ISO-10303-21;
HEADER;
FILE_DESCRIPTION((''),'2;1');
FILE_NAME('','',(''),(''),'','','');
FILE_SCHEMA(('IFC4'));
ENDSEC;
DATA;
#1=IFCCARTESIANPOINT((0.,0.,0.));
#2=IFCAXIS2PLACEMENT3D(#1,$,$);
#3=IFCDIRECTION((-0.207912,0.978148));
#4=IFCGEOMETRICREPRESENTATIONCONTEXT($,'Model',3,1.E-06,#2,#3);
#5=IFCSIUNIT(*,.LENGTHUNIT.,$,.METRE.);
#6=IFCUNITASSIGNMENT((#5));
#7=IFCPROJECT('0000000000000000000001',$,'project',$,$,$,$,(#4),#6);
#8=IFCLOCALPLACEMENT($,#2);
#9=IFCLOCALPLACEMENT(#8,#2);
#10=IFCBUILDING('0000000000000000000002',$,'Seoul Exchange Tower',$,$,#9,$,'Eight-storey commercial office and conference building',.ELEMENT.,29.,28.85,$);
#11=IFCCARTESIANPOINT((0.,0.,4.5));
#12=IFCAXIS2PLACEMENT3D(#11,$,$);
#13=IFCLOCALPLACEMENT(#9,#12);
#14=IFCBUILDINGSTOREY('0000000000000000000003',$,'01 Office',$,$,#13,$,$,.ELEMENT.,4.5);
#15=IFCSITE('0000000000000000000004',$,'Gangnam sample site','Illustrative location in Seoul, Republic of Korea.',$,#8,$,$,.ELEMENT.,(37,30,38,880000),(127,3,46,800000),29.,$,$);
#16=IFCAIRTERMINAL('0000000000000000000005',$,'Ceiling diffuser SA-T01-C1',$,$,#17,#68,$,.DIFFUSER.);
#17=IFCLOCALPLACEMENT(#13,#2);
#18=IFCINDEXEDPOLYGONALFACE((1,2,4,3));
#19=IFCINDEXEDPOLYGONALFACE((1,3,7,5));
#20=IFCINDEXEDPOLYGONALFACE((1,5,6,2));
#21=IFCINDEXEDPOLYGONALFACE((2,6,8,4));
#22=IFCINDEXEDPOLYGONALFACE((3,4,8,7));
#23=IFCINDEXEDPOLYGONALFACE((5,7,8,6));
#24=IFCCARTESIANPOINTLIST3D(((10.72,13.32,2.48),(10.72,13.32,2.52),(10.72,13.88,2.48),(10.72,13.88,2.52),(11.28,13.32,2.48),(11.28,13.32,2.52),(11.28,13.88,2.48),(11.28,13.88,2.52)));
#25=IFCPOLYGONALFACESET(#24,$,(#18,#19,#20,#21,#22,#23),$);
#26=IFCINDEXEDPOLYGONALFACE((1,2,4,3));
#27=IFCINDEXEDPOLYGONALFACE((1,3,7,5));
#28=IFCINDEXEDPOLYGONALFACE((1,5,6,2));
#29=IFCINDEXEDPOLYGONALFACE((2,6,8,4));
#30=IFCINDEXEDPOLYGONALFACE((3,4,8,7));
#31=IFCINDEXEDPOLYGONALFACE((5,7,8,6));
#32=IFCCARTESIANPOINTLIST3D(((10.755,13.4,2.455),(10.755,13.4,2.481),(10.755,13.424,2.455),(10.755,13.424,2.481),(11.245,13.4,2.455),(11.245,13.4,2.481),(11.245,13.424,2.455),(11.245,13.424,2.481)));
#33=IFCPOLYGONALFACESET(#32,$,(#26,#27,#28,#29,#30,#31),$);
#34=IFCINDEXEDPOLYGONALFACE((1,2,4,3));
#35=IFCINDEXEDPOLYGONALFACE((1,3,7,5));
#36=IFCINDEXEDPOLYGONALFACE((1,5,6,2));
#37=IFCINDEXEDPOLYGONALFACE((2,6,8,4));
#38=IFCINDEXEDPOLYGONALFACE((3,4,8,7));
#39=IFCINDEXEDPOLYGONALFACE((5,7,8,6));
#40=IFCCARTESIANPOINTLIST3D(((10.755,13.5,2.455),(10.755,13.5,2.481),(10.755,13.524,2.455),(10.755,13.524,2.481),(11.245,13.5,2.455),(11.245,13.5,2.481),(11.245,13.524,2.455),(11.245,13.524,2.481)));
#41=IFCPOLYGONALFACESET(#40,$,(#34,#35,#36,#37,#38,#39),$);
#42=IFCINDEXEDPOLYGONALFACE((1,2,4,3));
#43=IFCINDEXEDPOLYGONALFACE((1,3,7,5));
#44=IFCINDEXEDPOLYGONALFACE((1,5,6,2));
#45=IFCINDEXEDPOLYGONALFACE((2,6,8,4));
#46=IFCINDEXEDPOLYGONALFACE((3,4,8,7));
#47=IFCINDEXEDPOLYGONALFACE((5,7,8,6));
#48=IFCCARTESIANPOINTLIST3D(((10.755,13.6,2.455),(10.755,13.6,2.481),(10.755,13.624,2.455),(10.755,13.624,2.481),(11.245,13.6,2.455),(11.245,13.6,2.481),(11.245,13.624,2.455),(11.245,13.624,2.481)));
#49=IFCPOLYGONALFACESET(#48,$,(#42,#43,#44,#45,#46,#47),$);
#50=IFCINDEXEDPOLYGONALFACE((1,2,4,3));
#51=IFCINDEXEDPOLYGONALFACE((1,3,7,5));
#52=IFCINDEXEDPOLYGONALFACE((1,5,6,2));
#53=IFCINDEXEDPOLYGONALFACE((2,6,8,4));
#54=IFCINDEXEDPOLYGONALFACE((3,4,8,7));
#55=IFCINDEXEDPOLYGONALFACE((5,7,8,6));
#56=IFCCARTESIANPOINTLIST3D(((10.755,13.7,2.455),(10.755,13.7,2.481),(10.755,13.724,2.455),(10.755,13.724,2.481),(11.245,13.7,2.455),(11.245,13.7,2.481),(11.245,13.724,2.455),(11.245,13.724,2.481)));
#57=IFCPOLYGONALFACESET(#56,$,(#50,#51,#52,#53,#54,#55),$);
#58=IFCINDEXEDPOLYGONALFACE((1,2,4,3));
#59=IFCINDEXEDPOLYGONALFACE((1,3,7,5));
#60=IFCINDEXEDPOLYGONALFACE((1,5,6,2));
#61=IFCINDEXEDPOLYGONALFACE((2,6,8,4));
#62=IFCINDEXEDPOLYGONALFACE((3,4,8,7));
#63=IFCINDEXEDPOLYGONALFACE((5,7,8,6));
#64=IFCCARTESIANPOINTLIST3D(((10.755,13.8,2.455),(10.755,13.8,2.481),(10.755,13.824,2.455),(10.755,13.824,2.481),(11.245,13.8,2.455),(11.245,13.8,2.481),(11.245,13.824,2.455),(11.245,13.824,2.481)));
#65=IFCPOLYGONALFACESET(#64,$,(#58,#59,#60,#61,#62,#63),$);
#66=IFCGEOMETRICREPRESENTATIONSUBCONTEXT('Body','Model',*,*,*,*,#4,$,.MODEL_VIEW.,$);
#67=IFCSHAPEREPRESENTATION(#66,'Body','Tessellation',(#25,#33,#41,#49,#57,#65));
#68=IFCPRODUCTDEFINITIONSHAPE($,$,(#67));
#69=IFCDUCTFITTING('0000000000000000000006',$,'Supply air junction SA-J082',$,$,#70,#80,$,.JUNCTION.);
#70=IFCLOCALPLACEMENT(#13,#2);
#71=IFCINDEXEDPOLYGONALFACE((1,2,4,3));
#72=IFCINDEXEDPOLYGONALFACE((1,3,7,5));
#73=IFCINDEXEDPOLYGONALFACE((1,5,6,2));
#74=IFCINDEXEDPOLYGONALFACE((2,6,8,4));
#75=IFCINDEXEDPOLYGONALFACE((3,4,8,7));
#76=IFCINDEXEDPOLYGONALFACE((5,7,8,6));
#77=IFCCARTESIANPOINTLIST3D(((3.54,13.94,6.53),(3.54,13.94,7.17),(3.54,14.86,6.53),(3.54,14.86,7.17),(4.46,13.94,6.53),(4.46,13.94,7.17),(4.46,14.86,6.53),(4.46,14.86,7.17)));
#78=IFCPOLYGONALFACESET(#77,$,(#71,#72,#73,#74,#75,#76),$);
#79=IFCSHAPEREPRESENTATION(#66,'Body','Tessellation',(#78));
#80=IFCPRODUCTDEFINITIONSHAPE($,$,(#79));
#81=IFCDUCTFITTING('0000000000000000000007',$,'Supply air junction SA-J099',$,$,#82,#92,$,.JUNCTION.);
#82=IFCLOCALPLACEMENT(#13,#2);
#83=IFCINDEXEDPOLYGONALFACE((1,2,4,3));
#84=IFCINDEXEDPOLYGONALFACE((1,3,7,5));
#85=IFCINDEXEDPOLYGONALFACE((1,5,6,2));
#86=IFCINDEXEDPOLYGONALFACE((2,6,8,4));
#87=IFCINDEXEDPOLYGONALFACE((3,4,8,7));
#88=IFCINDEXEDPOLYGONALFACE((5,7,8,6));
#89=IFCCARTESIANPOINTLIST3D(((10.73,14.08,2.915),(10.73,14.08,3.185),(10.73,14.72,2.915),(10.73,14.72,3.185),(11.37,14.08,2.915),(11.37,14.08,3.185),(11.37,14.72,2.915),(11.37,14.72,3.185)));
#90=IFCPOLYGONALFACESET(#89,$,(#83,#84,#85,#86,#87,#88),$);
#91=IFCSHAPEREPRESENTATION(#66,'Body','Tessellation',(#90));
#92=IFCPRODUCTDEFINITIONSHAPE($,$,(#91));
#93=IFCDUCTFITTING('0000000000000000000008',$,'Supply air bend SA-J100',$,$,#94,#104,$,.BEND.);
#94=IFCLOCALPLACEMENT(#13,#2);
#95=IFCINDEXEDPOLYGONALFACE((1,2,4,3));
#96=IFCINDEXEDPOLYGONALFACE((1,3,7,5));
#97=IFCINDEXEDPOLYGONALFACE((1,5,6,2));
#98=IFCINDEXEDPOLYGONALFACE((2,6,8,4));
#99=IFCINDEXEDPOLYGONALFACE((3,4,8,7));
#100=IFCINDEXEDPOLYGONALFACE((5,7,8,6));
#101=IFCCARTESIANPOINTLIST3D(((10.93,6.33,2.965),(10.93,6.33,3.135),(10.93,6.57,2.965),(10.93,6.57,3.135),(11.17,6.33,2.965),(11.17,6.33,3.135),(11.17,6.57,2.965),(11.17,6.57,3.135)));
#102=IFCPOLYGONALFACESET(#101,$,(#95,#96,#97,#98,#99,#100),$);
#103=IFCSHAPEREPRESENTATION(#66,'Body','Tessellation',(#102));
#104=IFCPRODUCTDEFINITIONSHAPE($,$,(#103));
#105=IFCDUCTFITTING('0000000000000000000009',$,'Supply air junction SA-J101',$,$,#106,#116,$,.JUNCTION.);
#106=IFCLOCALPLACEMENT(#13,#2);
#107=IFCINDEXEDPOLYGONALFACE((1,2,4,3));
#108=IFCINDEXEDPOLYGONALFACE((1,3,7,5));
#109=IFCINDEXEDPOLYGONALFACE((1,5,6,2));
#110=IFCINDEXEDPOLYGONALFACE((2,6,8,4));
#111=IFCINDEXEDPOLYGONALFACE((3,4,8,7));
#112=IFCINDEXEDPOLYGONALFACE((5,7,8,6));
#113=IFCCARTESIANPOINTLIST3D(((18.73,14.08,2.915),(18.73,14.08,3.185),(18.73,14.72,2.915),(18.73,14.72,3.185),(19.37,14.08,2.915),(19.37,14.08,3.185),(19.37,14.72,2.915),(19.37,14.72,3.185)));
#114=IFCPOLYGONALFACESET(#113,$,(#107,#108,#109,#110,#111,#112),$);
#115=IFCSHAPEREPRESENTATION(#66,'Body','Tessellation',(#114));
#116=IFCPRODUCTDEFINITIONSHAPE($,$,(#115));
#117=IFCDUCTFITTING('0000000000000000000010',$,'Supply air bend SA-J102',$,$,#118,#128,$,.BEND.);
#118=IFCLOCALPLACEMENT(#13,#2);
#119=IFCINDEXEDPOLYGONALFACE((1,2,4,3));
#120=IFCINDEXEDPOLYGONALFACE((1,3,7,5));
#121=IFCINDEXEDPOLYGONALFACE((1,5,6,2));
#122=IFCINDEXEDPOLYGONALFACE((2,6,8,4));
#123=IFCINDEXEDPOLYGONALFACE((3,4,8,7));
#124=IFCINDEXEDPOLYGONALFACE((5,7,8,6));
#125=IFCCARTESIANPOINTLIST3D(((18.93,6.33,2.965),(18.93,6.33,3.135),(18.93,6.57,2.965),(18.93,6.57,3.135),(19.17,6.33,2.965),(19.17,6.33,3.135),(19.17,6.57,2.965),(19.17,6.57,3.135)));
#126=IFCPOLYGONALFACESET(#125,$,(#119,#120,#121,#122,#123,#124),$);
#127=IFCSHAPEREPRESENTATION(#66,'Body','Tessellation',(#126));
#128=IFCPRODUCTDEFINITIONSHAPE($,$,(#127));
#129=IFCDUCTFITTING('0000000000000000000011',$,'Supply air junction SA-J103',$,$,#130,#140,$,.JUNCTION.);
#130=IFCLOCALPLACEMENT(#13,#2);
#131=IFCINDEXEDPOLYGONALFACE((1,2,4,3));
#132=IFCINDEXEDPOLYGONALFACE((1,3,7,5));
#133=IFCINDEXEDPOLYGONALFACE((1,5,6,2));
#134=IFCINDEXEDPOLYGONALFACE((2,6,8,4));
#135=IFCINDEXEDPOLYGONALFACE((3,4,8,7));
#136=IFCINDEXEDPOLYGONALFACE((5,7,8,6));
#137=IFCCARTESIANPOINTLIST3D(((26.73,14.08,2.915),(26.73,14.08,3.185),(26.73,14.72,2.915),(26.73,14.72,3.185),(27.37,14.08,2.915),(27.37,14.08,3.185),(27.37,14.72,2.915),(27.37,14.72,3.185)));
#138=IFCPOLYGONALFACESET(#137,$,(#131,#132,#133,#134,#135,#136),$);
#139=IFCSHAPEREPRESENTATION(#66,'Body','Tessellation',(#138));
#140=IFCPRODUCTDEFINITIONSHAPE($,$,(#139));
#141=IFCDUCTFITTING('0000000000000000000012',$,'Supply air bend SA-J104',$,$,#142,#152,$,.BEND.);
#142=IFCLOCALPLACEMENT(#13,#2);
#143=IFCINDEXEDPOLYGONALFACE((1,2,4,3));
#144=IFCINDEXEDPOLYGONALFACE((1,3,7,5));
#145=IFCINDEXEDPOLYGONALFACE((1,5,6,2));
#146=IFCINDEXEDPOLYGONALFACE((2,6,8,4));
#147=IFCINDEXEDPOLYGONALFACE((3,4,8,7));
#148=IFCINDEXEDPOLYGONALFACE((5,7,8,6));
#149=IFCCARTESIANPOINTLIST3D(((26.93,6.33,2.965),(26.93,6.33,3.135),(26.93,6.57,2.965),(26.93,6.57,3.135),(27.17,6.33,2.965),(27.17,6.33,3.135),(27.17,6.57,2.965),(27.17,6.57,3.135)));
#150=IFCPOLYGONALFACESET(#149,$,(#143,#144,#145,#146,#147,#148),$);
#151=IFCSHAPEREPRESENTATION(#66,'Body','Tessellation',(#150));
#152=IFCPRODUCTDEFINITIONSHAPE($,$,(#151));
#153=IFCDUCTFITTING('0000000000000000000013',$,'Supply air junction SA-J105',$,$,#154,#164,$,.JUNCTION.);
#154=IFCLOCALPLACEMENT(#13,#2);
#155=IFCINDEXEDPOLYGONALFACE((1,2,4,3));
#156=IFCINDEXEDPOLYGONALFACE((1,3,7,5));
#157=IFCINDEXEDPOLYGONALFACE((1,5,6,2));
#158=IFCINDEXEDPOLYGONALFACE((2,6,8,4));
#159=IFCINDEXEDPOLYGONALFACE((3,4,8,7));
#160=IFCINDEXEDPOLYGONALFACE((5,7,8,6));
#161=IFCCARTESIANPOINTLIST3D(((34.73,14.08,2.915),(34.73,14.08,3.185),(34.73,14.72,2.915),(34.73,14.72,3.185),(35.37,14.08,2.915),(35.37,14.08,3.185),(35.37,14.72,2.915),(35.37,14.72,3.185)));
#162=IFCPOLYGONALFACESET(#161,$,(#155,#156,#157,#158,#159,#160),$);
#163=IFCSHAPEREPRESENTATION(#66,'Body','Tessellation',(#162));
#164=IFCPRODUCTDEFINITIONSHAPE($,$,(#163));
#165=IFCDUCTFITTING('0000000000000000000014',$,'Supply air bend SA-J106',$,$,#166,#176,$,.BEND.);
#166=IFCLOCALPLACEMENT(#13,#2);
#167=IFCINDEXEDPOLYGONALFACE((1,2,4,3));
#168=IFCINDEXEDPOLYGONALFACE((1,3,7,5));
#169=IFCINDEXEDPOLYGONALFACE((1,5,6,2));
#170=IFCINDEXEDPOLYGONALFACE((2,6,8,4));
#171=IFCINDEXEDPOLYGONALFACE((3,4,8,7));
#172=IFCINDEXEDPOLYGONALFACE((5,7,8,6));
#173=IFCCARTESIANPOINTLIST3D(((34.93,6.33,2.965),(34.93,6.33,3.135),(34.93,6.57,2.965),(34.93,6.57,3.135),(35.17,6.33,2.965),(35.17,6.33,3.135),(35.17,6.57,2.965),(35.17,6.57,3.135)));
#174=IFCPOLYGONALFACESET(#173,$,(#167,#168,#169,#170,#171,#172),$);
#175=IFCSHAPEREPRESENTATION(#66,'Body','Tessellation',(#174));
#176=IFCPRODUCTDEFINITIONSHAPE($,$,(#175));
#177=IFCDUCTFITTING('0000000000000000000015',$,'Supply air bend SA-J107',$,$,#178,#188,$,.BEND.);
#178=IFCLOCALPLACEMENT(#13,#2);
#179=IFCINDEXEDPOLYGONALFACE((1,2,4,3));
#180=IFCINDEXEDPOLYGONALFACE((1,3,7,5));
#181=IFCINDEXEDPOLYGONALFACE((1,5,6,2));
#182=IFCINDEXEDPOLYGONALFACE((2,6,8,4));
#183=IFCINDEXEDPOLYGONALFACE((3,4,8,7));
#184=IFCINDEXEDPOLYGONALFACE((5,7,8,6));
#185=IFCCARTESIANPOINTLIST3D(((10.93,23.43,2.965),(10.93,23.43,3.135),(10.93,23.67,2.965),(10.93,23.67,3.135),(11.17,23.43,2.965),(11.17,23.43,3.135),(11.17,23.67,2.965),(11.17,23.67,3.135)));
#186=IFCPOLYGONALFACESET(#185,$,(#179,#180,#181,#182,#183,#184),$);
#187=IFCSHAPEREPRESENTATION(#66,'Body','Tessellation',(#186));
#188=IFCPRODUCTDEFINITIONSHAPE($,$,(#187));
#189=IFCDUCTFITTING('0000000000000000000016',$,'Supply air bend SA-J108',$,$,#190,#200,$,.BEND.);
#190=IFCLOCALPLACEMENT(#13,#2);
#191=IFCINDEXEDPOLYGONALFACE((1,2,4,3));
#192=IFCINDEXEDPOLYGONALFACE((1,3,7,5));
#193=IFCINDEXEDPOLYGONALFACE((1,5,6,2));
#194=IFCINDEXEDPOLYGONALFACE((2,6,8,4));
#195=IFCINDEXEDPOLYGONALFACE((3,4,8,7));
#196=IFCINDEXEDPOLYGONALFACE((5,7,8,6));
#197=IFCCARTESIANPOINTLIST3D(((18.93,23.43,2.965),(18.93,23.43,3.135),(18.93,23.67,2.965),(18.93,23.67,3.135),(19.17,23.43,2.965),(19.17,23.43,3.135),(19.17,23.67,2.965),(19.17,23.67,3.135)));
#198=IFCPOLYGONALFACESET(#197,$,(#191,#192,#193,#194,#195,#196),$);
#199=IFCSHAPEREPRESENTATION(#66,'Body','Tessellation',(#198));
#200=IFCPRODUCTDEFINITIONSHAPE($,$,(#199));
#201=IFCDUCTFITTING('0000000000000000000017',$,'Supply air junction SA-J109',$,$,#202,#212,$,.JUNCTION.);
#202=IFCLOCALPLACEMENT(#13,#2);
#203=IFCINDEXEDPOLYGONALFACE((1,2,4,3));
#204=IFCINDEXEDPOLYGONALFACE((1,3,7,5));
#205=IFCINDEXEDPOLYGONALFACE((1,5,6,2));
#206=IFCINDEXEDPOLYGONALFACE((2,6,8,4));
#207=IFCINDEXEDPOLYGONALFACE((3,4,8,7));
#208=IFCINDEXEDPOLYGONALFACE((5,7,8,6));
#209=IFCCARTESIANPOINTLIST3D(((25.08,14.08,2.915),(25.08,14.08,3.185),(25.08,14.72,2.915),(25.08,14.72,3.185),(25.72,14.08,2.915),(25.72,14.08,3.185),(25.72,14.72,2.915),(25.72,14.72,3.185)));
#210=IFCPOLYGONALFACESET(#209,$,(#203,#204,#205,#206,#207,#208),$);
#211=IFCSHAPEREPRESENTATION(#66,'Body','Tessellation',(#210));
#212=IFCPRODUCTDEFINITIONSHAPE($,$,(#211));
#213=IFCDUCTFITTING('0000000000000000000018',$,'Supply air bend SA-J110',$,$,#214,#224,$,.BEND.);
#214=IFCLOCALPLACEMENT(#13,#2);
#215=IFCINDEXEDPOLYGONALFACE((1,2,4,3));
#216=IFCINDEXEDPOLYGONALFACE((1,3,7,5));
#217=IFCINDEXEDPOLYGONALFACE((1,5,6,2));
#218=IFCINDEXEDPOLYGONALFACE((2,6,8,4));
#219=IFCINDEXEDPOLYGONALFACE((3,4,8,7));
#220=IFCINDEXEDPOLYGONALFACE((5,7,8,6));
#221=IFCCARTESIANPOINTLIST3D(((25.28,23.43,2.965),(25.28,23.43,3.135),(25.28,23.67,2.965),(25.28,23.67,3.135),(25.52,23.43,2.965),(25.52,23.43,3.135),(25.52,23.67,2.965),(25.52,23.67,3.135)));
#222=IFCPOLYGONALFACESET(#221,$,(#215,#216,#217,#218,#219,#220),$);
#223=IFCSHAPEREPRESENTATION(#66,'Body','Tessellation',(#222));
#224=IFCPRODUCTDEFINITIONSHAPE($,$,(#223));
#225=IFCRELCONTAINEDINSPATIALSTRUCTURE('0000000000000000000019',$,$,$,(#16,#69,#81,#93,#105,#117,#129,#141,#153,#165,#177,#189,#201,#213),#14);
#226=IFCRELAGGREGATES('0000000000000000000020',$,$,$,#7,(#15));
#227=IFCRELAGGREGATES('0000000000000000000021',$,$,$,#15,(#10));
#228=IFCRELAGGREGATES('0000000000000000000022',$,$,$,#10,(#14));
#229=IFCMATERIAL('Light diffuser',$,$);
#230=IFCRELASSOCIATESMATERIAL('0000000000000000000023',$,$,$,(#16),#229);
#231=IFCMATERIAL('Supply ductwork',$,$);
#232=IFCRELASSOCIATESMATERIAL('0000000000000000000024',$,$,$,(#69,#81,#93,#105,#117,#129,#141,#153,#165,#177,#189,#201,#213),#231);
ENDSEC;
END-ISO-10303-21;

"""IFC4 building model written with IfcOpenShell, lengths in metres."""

from ifc_helpers import new_model, si_unit, direction, frame, frame_2d, origin, place, context, subcontext, project, spatial, rectangle, extrude, material, element, save


model = new_model("IFC4")

# Units and contexts
model_context = context("Model", 3, precision=1e-06, world=origin(), true_north=direction((-0.207912, 0.978148)))
body_context = subcontext(model_context, "Body", "Model", "MODEL_VIEW")
ifc_project = project(units=[si_unit("LENGTHUNIT", "METRE")], contexts=[model_context])

# Site, building, storey
site_placement = place(None, origin())
site = spatial("IfcSite", under=ifc_project, at=site_placement, Name="Gangnam sample site", Description="Illustrative location in Seoul, Republic of Korea.", CompositionType="ELEMENT", RefLatitude=(37, 30, 38, 880000), RefLongitude=(127, 3, 46, 800000), RefElevation=29.0)
building_placement = place(site_placement, origin())
building = spatial("IfcBuilding", under=site, at=building_placement, Name="Seoul Exchange Tower", LongName="Eight-storey commercial office and conference building", CompositionType="ELEMENT", ElevationOfRefHeight=29.0, ElevationOfTerrain=28.85)
storey_placement = place(building_placement, frame((0.0, 0.0, 4.5)))
storey = spatial("IfcBuildingStorey", under=building, at=storey_placement, Name="01 Office", CompositionType="ELEMENT", Elevation=4.5)

# Shared definitions
placement = place(storey_placement, origin())

# Shared definitions
ifc_material_1 = material(Name="Light diffuser")

# Air terminal
element("IfcAirTerminal", 1, at=placement, inside=storey, material=ifc_material_1, Name="Ceiling diffuser SA-T01-C1", PredefinedType="DIFFUSER", context=body_context, shape_type="SweptSolid", body=[
    extrude(rectangle(XDim=0.56, YDim=0.56, at=frame_2d((0.28, 0.28))), frame((10.72, 13.32, 2.48)), (0.0, 0.0, 1.0), 0.04),
    extrude(rectangle(XDim=0.49, YDim=0.024, at=frame_2d((0.245, 0.012))), frame((10.755, 13.4, 2.455)), (0.0, 0.0, 1.0), 0.026),
    extrude(rectangle(XDim=0.49, YDim=0.024, at=frame_2d((0.245, 0.012))), frame((10.755, 13.5, 2.455)), (0.0, 0.0, 1.0), 0.026),
    extrude(rectangle(XDim=0.49, YDim=0.024, at=frame_2d((0.245, 0.012))), frame((10.755, 13.6, 2.455)), (0.0, 0.0, 1.0), 0.026),
    extrude(rectangle(XDim=0.49, YDim=0.024, at=frame_2d((0.245, 0.012))), frame((10.755, 13.7, 2.455)), (0.0, 0.0, 1.0), 0.026),
    extrude(rectangle(XDim=0.49, YDim=0.024, at=frame_2d((0.245, 0.012))), frame((10.755, 13.8, 2.455)), (0.0, 0.0, 1.0), 0.026),
])

# Duct fittings
ifc_material_2 = material(Name="Supply ductwork")
element("IfcDuctFitting", 2, at=placement, inside=storey, material=ifc_material_2, Name="Supply air junction SA-J082", PredefinedType="JUNCTION", context=body_context, shape_type="SweptSolid", body=[
    extrude(rectangle(XDim=0.92, YDim=0.92, at=frame_2d((0.46, 0.46))), frame((3.54, 13.94, 6.53)), (0.0, 0.0, 1.0), 0.64),
])
element("IfcDuctFitting", 3, at=placement, inside=storey, material=ifc_material_2, Name="Supply air junction SA-J099", PredefinedType="JUNCTION", context=body_context, shape_type="SweptSolid", body=[
    extrude(rectangle(XDim=0.64, YDim=0.64, at=frame_2d((0.32, 0.32))), frame((10.73, 14.08, 2.915)), (0.0, 0.0, 1.0), 0.27),
])
element("IfcDuctFitting", 4, at=placement, inside=storey, material=ifc_material_2, Name="Supply air bend SA-J100", PredefinedType="BEND", context=body_context, shape_type="SweptSolid", body=[
    extrude(rectangle(XDim=0.24, YDim=0.24, at=frame_2d((0.12, 0.12))), frame((10.93, 6.33, 2.965)), (0.0, 0.0, 1.0), 0.17),
])
element("IfcDuctFitting", 5, at=placement, inside=storey, material=ifc_material_2, Name="Supply air junction SA-J101", PredefinedType="JUNCTION", context=body_context, shape_type="SweptSolid", body=[
    extrude(rectangle(XDim=0.64, YDim=0.64, at=frame_2d((0.32, 0.32))), frame((18.73, 14.08, 2.915)), (0.0, 0.0, 1.0), 0.27),
])
element("IfcDuctFitting", 6, at=placement, inside=storey, material=ifc_material_2, Name="Supply air bend SA-J102", PredefinedType="BEND", context=body_context, shape_type="SweptSolid", body=[
    extrude(rectangle(XDim=0.24, YDim=0.24, at=frame_2d((0.12, 0.12))), frame((18.93, 6.33, 2.965)), (0.0, 0.0, 1.0), 0.17),
])
element("IfcDuctFitting", 7, at=placement, inside=storey, material=ifc_material_2, Name="Supply air junction SA-J103", PredefinedType="JUNCTION", context=body_context, shape_type="SweptSolid", body=[
    extrude(rectangle(XDim=0.64, YDim=0.64, at=frame_2d((0.32, 0.32))), frame((26.73, 14.08, 2.915)), (0.0, 0.0, 1.0), 0.27),
])
element("IfcDuctFitting", 8, at=placement, inside=storey, material=ifc_material_2, Name="Supply air bend SA-J104", PredefinedType="BEND", context=body_context, shape_type="SweptSolid", body=[
    extrude(rectangle(XDim=0.24, YDim=0.24, at=frame_2d((0.12, 0.12))), frame((26.93, 6.33, 2.965)), (0.0, 0.0, 1.0), 0.17),
])
element("IfcDuctFitting", 9, at=placement, inside=storey, material=ifc_material_2, Name="Supply air junction SA-J105", PredefinedType="JUNCTION", context=body_context, shape_type="SweptSolid", body=[
    extrude(rectangle(XDim=0.64, YDim=0.64, at=frame_2d((0.32, 0.32))), frame((34.73, 14.08, 2.915)), (0.0, 0.0, 1.0), 0.27),
])
element("IfcDuctFitting", 10, at=placement, inside=storey, material=ifc_material_2, Name="Supply air bend SA-J106", PredefinedType="BEND", context=body_context, shape_type="SweptSolid", body=[
    extrude(rectangle(XDim=0.24, YDim=0.24, at=frame_2d((0.12, 0.12))), frame((34.93, 6.33, 2.965)), (0.0, 0.0, 1.0), 0.17),
])
element("IfcDuctFitting", 11, at=placement, inside=storey, material=ifc_material_2, Name="Supply air bend SA-J107", PredefinedType="BEND", context=body_context, shape_type="SweptSolid", body=[
    extrude(rectangle(XDim=0.24, YDim=0.24, at=frame_2d((0.12, 0.12))), frame((10.93, 23.43, 2.965)), (0.0, 0.0, 1.0), 0.17),
])
element("IfcDuctFitting", 12, at=placement, inside=storey, material=ifc_material_2, Name="Supply air bend SA-J108", PredefinedType="BEND", context=body_context, shape_type="SweptSolid", body=[
    extrude(rectangle(XDim=0.24, YDim=0.24, at=frame_2d((0.12, 0.12))), frame((18.93, 23.43, 2.965)), (0.0, 0.0, 1.0), 0.17),
])
element("IfcDuctFitting", 13, at=placement, inside=storey, material=ifc_material_2, Name="Supply air junction SA-J109", PredefinedType="JUNCTION", context=body_context, shape_type="SweptSolid", body=[
    extrude(rectangle(XDim=0.64, YDim=0.64, at=frame_2d((0.32, 0.32))), frame((25.08, 14.08, 2.915)), (0.0, 0.0, 1.0), 0.27),
])
element("IfcDuctFitting", 14, at=placement, inside=storey, material=ifc_material_2, Name="Supply air bend SA-J110", PredefinedType="BEND", context=body_context, shape_type="SweptSolid", body=[
    extrude(rectangle(XDim=0.24, YDim=0.24, at=frame_2d((0.12, 0.12))), frame((25.28, 23.43, 2.965)), (0.0, 0.0, 1.0), 0.17),
])

save(model, "model.ifc")
